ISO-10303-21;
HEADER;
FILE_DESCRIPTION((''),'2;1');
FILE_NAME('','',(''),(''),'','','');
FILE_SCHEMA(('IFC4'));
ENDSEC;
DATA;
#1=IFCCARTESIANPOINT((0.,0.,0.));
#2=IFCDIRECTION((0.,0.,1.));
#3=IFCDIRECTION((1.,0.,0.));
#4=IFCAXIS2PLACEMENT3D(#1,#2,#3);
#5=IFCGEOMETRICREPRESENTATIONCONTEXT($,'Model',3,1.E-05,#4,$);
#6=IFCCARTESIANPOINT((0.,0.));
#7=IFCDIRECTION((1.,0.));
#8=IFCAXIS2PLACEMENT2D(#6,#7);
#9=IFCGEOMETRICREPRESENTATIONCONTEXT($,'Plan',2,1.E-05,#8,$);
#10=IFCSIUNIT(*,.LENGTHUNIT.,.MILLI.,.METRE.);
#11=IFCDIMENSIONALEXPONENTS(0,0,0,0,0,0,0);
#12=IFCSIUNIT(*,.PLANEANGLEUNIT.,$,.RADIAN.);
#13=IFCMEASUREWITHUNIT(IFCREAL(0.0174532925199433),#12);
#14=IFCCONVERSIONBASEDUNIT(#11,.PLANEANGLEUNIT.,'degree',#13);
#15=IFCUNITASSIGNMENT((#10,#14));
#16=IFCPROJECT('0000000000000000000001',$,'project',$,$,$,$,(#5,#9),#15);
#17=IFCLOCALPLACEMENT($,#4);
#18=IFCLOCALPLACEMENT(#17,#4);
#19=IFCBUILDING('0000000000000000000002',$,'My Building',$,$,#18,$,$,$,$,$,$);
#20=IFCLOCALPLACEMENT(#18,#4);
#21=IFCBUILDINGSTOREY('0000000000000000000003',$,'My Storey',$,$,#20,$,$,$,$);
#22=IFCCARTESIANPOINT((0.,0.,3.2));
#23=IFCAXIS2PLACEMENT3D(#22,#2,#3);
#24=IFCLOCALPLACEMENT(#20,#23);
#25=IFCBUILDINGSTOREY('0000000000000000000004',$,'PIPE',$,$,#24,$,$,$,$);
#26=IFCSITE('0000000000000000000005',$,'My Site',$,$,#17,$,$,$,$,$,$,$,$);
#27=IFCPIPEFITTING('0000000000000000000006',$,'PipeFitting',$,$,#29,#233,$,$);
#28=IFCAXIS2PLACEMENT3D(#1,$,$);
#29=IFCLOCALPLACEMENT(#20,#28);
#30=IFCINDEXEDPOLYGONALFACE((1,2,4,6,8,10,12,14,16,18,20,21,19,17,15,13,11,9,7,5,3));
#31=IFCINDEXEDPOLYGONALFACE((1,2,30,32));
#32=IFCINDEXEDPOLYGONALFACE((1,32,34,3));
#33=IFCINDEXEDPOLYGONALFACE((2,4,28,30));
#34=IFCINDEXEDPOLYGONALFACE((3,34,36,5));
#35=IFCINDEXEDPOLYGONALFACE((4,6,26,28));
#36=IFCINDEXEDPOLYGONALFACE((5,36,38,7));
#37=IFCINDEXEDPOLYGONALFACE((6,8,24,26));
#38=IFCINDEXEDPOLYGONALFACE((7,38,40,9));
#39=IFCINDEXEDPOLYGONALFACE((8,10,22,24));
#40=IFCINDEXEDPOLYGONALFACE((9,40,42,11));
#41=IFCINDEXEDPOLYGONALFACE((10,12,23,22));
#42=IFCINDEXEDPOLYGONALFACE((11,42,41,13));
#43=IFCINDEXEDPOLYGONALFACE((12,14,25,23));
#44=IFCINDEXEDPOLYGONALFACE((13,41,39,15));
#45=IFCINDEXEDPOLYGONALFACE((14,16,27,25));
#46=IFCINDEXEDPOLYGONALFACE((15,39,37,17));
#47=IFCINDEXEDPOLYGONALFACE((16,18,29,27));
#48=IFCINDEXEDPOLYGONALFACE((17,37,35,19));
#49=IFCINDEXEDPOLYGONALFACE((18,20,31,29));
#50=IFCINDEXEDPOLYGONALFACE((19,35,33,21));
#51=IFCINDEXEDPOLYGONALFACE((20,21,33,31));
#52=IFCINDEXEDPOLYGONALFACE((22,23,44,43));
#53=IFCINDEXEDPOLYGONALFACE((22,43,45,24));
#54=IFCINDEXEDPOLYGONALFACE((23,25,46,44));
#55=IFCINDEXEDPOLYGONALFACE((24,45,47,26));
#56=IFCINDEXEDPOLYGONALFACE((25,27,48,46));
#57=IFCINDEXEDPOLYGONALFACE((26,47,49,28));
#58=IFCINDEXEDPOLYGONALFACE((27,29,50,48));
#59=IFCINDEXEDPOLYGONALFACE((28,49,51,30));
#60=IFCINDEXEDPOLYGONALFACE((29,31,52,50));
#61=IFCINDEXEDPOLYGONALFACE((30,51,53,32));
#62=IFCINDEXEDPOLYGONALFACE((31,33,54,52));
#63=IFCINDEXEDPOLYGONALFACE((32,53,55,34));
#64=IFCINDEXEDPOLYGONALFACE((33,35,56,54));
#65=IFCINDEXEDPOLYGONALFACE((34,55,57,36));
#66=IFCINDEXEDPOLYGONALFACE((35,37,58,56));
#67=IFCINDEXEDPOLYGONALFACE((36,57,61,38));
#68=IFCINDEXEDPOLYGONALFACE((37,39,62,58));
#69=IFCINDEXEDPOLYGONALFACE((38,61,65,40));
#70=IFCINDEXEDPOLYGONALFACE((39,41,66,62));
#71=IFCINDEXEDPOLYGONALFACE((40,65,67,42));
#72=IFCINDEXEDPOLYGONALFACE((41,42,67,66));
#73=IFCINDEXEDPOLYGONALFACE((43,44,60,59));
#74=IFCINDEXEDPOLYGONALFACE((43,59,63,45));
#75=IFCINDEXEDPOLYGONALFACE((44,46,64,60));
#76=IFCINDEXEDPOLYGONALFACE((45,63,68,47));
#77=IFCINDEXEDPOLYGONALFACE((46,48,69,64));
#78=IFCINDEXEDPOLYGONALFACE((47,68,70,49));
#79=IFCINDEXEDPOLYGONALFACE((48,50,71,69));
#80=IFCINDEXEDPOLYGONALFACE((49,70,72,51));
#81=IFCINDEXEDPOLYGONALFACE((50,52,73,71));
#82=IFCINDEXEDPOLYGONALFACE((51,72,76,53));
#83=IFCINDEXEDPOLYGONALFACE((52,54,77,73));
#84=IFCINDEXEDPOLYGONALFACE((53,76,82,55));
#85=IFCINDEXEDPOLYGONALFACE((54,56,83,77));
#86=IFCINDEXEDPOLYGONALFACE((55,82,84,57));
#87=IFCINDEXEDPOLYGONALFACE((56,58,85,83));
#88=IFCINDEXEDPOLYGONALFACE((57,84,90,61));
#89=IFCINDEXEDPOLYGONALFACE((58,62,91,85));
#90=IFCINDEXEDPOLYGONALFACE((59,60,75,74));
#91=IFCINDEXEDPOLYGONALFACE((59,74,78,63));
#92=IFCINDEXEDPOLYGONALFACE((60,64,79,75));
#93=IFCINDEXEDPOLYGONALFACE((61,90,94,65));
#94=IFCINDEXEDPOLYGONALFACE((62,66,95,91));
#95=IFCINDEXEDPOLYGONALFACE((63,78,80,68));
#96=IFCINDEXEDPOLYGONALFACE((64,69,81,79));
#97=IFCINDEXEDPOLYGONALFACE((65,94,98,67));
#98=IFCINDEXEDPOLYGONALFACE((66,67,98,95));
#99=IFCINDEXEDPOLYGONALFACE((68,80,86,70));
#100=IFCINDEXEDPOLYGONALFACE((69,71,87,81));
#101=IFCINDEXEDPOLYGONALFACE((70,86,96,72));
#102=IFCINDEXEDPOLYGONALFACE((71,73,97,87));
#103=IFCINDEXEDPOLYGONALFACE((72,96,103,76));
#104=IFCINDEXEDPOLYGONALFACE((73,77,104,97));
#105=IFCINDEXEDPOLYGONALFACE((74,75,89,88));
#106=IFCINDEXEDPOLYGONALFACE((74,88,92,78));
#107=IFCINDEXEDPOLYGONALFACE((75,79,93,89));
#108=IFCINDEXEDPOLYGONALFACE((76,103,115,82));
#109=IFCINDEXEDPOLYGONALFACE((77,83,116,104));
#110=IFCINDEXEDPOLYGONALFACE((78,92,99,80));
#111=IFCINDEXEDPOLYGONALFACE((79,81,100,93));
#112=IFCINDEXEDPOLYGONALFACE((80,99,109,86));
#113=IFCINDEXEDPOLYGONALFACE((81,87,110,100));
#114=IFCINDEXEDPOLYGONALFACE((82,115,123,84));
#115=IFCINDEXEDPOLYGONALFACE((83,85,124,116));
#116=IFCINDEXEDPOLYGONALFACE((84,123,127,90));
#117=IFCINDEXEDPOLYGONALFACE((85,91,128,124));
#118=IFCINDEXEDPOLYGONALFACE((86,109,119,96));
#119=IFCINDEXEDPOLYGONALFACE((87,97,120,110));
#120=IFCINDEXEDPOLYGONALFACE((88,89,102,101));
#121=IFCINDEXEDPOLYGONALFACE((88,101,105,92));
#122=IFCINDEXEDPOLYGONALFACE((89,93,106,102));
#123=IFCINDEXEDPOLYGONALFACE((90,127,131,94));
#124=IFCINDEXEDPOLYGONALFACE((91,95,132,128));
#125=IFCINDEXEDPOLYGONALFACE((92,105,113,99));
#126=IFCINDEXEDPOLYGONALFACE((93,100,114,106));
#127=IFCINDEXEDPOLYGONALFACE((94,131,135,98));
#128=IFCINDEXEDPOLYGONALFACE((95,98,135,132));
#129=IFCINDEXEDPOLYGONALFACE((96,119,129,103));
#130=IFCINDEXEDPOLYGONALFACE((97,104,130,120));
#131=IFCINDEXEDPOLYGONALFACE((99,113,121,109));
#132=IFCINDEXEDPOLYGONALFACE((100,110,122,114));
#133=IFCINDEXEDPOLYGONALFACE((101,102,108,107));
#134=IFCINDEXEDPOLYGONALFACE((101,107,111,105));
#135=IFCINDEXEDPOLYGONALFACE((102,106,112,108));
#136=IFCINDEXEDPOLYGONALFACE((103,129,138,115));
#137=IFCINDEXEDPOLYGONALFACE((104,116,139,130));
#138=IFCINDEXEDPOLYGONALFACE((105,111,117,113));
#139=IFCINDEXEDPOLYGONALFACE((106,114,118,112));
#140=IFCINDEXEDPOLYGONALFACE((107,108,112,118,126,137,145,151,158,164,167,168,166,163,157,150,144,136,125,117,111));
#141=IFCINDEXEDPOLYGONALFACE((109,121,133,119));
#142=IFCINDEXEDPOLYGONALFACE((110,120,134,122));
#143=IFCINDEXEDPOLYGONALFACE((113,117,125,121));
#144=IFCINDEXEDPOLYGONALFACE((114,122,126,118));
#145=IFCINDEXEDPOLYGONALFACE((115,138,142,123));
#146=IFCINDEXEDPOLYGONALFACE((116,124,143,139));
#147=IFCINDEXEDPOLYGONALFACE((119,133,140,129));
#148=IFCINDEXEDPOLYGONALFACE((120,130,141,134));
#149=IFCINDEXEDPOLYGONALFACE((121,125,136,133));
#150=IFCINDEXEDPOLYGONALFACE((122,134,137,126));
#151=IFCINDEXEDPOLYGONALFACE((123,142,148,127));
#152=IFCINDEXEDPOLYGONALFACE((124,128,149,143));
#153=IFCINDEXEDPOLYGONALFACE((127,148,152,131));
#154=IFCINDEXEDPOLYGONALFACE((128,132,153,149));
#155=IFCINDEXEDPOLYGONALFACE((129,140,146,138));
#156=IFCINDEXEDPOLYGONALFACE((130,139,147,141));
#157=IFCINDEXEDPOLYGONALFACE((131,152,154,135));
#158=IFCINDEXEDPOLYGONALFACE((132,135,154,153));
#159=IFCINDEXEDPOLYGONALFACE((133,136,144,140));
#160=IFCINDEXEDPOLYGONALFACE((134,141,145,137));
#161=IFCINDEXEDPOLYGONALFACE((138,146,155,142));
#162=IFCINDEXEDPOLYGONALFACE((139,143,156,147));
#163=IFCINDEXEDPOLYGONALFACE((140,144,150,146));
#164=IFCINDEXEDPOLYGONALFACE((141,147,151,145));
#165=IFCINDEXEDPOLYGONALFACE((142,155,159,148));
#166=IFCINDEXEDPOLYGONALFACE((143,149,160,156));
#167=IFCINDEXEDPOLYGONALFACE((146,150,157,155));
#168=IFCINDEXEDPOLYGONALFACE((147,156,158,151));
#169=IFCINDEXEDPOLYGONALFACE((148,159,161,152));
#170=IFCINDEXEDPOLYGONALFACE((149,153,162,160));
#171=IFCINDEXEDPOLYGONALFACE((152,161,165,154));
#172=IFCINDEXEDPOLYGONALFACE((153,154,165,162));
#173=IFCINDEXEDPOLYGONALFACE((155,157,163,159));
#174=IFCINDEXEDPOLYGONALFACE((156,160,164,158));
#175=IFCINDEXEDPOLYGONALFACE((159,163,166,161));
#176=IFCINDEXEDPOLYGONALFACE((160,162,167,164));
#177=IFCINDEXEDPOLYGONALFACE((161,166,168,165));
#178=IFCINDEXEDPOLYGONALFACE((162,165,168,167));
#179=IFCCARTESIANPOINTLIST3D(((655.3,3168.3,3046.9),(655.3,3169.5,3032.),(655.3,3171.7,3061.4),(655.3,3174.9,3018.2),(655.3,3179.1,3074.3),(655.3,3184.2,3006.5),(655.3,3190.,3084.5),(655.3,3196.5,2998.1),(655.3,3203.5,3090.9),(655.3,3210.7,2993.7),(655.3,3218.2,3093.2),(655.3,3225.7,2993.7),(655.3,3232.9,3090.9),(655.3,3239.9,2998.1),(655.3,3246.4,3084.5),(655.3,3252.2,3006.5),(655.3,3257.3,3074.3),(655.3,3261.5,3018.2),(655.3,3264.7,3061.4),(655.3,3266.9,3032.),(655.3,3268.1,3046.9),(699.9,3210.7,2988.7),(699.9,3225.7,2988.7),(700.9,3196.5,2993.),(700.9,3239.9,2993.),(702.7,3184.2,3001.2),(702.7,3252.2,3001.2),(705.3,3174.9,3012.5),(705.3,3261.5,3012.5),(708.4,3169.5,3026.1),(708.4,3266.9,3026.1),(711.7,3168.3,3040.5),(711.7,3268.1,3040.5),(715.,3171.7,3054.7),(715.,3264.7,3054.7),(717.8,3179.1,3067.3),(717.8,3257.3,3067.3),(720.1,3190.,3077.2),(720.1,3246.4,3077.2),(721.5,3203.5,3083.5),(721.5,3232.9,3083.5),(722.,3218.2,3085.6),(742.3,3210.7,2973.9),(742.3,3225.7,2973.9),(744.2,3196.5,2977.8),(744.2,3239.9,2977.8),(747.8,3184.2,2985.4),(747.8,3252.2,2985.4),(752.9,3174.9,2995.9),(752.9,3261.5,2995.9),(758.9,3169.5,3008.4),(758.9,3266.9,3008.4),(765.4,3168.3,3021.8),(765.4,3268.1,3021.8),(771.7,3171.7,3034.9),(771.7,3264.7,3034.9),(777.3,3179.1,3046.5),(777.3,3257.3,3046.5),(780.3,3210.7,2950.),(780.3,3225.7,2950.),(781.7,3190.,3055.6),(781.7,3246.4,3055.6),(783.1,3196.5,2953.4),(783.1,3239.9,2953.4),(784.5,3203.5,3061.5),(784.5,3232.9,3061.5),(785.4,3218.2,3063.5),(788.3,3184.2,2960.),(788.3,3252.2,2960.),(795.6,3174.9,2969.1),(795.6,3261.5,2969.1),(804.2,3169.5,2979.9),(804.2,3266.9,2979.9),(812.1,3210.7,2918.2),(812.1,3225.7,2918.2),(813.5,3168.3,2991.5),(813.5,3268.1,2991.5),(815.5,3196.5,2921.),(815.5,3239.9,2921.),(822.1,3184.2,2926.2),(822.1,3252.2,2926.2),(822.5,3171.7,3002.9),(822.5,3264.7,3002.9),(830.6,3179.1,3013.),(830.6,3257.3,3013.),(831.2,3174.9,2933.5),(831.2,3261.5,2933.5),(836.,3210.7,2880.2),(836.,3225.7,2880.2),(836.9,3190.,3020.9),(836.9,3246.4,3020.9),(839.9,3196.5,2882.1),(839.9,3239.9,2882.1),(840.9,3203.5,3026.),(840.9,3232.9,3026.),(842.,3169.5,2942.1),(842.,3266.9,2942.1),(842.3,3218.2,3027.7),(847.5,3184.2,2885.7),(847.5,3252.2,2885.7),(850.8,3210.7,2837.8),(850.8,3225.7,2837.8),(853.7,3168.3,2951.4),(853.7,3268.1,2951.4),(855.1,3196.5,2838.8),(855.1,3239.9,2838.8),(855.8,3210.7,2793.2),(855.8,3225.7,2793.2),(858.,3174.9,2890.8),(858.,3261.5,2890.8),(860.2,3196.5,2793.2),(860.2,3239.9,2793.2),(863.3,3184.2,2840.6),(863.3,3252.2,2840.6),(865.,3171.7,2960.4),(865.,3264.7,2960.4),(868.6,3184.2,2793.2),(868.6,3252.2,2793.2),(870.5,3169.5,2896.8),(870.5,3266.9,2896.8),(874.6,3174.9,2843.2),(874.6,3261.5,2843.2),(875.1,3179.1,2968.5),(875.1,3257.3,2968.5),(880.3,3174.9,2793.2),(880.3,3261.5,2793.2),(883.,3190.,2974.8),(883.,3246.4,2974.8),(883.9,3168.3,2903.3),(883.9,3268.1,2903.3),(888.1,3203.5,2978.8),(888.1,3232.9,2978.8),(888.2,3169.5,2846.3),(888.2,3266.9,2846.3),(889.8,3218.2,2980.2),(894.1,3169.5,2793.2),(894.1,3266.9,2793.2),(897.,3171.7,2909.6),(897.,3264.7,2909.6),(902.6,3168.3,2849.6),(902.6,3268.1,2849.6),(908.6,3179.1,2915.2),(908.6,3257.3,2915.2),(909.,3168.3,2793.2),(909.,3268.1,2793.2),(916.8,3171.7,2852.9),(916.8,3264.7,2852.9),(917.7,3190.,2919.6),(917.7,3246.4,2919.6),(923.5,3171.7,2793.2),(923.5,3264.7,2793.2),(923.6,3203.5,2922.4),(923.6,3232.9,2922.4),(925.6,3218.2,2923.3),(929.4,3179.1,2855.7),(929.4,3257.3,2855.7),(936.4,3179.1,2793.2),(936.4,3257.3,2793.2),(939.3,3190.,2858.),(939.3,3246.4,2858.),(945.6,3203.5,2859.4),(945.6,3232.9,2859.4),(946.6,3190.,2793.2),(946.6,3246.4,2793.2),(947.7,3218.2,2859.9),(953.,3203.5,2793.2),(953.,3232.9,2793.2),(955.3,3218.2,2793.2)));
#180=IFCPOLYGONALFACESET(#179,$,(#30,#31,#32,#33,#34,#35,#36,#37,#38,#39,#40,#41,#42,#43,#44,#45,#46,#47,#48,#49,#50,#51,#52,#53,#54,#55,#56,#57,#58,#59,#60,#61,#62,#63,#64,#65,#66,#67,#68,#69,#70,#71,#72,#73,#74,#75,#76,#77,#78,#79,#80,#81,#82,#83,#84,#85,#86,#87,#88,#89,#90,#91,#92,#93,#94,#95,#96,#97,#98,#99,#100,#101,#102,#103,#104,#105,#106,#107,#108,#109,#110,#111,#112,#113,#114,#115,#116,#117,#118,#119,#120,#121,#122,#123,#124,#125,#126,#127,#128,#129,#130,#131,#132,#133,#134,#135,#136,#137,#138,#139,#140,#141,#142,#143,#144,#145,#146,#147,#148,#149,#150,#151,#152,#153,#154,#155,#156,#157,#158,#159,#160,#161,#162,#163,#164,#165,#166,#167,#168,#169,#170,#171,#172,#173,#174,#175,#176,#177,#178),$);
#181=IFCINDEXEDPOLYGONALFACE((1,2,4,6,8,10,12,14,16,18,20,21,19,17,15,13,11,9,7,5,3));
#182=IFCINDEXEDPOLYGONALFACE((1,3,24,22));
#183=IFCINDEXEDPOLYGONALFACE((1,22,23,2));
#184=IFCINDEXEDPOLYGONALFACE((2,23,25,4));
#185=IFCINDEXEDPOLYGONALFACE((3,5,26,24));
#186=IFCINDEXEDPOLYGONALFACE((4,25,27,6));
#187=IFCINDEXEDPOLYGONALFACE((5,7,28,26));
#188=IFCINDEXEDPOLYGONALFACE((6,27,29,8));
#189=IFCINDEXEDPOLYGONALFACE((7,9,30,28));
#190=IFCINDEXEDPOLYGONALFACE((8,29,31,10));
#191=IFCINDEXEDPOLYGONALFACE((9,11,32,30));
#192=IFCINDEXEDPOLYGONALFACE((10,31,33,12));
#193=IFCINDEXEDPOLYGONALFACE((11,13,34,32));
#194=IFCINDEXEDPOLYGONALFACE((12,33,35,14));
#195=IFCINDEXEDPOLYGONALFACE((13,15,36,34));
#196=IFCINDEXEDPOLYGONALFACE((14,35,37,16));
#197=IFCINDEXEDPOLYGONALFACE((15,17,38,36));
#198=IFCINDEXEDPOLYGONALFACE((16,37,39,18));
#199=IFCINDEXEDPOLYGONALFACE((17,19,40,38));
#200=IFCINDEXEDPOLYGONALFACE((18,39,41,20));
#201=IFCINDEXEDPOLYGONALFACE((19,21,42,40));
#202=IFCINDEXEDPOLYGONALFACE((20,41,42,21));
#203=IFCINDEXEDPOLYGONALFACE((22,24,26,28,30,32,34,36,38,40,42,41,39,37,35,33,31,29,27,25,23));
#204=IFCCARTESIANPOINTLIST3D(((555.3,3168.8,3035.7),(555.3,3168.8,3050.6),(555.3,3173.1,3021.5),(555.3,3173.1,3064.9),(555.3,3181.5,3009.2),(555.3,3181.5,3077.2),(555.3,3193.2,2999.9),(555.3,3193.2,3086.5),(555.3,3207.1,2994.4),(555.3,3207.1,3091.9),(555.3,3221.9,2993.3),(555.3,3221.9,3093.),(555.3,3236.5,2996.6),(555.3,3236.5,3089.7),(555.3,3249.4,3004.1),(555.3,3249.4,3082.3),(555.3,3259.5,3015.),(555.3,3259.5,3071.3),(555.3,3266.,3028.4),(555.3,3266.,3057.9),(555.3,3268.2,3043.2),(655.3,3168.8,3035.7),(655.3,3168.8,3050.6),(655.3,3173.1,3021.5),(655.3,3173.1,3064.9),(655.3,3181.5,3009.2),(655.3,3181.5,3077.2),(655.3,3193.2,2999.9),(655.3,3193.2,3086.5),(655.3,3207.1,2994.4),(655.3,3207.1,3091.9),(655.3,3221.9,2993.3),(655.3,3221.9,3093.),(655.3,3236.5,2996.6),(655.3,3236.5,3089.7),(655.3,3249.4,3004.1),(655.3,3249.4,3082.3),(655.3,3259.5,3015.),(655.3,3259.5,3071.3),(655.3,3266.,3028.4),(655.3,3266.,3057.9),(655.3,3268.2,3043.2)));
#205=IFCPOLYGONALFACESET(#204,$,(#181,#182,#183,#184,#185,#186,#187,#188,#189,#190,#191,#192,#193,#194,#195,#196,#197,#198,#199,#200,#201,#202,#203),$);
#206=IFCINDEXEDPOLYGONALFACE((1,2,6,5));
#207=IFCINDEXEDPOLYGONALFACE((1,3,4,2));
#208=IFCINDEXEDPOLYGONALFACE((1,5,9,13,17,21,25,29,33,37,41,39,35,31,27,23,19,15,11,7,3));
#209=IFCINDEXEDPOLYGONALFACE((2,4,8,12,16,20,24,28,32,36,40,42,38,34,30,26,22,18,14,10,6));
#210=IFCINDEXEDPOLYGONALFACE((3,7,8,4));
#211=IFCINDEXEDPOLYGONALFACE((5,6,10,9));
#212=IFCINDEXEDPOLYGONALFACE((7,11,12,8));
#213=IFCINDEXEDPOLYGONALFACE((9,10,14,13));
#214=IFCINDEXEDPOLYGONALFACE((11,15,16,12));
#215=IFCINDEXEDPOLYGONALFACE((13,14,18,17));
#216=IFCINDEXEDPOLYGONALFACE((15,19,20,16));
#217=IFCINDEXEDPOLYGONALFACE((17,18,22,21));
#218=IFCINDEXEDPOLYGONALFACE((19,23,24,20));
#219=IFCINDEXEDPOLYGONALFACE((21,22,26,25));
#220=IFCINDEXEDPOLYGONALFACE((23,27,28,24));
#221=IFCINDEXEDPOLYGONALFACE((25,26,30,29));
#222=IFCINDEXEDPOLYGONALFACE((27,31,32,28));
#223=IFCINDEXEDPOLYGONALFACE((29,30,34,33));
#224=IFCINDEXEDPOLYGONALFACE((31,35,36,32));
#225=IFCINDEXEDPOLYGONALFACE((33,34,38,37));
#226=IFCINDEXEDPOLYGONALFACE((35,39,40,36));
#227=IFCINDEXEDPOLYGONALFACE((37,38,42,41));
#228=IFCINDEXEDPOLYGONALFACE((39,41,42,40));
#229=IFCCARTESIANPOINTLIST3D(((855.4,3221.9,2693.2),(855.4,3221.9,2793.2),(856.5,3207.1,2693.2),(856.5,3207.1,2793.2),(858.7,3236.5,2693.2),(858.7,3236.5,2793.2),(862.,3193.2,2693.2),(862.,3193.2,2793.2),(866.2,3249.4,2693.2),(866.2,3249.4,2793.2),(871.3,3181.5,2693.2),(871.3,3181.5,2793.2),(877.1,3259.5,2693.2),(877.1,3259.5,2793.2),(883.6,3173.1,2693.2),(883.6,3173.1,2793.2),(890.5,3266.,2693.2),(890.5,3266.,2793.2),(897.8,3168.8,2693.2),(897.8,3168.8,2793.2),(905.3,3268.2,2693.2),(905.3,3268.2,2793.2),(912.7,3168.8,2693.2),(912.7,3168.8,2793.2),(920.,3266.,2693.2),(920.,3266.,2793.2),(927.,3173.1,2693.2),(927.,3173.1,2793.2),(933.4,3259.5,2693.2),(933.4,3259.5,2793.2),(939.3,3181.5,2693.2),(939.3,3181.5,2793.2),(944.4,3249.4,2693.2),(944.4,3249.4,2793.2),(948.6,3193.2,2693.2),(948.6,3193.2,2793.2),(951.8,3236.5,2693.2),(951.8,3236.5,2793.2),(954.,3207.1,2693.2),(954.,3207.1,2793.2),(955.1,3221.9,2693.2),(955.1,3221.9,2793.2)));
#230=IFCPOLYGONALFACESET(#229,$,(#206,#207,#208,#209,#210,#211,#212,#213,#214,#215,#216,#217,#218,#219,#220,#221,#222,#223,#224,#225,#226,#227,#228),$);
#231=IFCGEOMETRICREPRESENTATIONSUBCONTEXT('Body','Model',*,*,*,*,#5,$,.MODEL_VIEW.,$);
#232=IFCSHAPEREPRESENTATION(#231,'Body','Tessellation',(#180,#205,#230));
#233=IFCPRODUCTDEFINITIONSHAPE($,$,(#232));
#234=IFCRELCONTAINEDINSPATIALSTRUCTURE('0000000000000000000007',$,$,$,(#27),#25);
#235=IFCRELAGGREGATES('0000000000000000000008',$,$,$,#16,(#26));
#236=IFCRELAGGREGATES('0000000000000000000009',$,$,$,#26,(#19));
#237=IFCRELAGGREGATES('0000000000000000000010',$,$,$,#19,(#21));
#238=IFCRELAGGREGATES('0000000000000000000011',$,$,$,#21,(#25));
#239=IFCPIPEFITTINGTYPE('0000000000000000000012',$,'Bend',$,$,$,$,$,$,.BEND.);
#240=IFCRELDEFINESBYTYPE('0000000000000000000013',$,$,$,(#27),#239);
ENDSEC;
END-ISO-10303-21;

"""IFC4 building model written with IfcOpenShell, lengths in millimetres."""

from ifc_helpers import new_model, entity, si_unit, converted_unit, frame, origin_with_axes, origin_2d_with_axis, place, context, subcontext, project, spatial, circle, extrude, source, transform, mapped, type_object, type_shapes, element, save


model = new_model("IFC4")

# Units and contexts
model_context = context("Model", 3, precision=1e-05, world=origin_with_axes())
plan_context = context("Plan", 2, precision=1e-05, world=origin_2d_with_axis())
body_context = subcontext(model_context, "Body", "Model", "MODEL_VIEW")
ifc_project = project(units=[si_unit("LENGTHUNIT", "METRE", prefix="MILLI"), converted_unit("PLANEANGLEUNIT", "degree", entity("IfcReal", 0.0174532925199433), si_unit("PLANEANGLEUNIT", "RADIAN"), dimensions=[0, 0, 0, 0, 0, 0, 0])], contexts=[model_context, plan_context])

# Site, building, storeys
site_placement = place(None, origin_with_axes())
site = spatial("IfcSite", under=ifc_project, at=site_placement, Name="My Site")
building_placement = place(site_placement, origin_with_axes())
building = spatial("IfcBuilding", under=site, at=building_placement, Name="My Building")
storey_1_placement = place(building_placement, origin_with_axes())
storey_1 = spatial("IfcBuildingStorey", under=building, at=storey_1_placement, Name="My Storey")
storey_2_placement = place(storey_1_placement, frame((0.0, 0.0, 3.2), z_axis=(0.0, 0.0, 1.0), x_axis=(1.0, 0.0, 0.0)))
storey_2 = spatial("IfcBuildingStorey", under=storey_1, at=storey_2_placement, Name="PIPE")

# Pipe fitting
pipe_fitting_type = type_object("IfcPipeFittingType", Name="Bend", PredefinedType="BEND")
shared_shape = source(origin_with_axes(), body_context, "Body", "SolidModel", [
    entity("IfcSweptDiskSolid", entity("IfcIndexedPolyCurve", entity("IfcCartesianPointList3D", [[0.0, 0.0, 100.0], [0.0, -73.2, 276.8], [0.0, -250.0, 350.0]]), [entity("IfcArcIndex", [1, 2, 3])]), 50.0),
    extrude(circle(Radius=50.0), origin_with_axes(), (0.0, 0.0, 1.0), 100.0),
    extrude(circle(Radius=50.0), frame((0.0, -250.0, 350.0), z_axis=(0.0, -1.0, 0.0), x_axis=(1.0, 0.0, 0.0)), (0.0, 0.0, 1.0), 100.0),
])
type_shapes(pipe_fitting_type, [shared_shape])
for number, where, z_axis, x_axis, name in (
    (1, (555.3, 3218.2, 3040.0), (1.0, 0.0, 0.0), (0.0, 1.0, 0.0), "PipeFitting"),
):
    element("IfcPipeFitting", number, at=place(storey_2_placement, frame(where, z_axis=z_axis, x_axis=x_axis)), inside=storey_2, type_object=pipe_fitting_type, Name=name, context=body_context, shape_type="MappedRepresentation", body=[
        mapped(shared_shape, transform((0.0, 0.0, 0.0), x_axis=(1.0, 0.0, 0.0), y_axis=(0.0, 1.0, 0.0), z_axis=(0.0, 0.0, 1.0), scale=1.0)),
    ])

save(model, "model.ifc")
